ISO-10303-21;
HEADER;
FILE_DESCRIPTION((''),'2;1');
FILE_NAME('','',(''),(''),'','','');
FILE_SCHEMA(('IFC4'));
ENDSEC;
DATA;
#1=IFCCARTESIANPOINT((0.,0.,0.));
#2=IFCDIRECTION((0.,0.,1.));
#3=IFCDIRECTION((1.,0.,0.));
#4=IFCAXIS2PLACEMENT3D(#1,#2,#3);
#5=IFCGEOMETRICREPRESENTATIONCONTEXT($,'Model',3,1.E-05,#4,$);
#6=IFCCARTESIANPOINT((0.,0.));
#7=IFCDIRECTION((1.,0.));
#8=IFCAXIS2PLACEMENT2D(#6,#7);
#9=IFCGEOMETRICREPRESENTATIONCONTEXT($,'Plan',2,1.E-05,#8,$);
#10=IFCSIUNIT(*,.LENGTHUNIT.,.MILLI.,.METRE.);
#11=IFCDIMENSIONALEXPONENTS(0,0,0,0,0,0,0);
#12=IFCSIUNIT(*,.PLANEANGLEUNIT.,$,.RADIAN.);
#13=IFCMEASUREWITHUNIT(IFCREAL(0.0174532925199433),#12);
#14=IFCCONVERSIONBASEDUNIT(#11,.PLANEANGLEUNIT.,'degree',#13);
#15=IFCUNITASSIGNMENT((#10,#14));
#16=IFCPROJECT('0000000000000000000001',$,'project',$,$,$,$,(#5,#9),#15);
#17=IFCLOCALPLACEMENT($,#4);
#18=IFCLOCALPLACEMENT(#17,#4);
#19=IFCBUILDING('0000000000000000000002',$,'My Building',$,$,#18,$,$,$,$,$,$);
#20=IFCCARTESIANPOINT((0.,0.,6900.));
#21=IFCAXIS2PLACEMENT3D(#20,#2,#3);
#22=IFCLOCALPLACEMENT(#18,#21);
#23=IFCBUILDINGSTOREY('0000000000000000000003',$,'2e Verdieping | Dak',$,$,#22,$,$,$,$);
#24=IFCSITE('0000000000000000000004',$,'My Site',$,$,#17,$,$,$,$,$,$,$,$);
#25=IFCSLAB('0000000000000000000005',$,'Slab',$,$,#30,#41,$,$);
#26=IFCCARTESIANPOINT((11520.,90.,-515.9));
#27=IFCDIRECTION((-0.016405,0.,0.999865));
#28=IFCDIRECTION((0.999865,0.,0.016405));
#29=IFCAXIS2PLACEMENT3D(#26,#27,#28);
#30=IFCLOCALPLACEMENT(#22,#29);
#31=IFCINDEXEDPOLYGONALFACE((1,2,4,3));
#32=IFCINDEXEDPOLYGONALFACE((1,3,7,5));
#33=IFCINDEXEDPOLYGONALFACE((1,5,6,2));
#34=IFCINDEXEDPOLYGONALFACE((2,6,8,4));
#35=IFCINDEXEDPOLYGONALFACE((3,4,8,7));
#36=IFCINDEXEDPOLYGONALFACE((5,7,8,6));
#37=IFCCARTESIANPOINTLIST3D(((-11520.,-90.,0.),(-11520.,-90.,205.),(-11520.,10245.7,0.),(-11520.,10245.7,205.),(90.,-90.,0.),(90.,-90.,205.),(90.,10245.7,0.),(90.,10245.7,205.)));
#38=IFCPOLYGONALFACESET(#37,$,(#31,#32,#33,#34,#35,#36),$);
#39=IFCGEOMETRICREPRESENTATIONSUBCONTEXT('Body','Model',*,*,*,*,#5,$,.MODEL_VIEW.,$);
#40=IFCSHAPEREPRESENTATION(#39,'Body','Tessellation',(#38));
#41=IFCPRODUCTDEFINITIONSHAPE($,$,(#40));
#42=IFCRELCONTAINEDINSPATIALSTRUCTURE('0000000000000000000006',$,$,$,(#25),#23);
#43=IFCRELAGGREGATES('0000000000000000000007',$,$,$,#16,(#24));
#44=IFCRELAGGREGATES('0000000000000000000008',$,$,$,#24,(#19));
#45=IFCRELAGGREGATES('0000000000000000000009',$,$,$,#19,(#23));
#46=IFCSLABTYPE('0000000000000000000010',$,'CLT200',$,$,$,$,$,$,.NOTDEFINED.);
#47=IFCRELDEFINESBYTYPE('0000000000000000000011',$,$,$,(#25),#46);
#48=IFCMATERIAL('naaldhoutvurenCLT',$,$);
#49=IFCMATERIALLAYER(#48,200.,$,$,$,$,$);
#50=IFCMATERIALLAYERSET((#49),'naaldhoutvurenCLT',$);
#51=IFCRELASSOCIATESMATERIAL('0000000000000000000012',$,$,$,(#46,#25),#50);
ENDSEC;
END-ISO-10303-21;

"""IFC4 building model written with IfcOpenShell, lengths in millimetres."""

from ifc_helpers import new_model, entity, si_unit, converted_unit, frame, origin_with_axes, origin_2d_with_axis, place, context, subcontext, project, spatial, line, indexed_curve, outline, extrude, material, layer, layer_set, layer_usage, type_object, element, save


model = new_model("IFC4")

# Units and contexts
model_context = context("Model", 3, precision=1e-05, world=origin_with_axes())
plan_context = context("Plan", 2, precision=1e-05, world=origin_2d_with_axis())
body_context = subcontext(model_context, "Body", "Model", "MODEL_VIEW")
ifc_project = project(units=[si_unit("LENGTHUNIT", "METRE", prefix="MILLI"), converted_unit("PLANEANGLEUNIT", "degree", entity("IfcReal", 0.0174532925199433), si_unit("PLANEANGLEUNIT", "RADIAN"), dimensions=[0, 0, 0, 0, 0, 0, 0])], contexts=[model_context, plan_context])

# Site, building, storey
site_placement = place(None, origin_with_axes())
site = spatial("IfcSite", under=ifc_project, at=site_placement, Name="My Site")
building_placement = place(site_placement, origin_with_axes())
building = spatial("IfcBuilding", under=site, at=building_placement, Name="My Building")
storey_placement = place(building_placement, frame((0.0, 0.0, 6900.0), z_axis=(0.0, 0.0, 1.0), x_axis=(1.0, 0.0, 0.0)))
storey = spatial("IfcBuildingStorey", under=building, at=storey_placement, Name="2e Verdieping | Dak")

# Slab
ifc_material_1 = material(Name="naaldhoutvurenCLT")
ifc_layer_1 = layer(ifc_material_1, 200.0)
ifc_layer_set_1 = layer_set([ifc_layer_1], Name="naaldhoutvurenCLT")
ifc_layer_usage_1 = layer_usage(ifc_layer_set_1, "AXIS3", "POSITIVE", 0.0)
slab_type_1 = type_object("IfcSlabType", Name="CLT200", PredefinedType="NOTDEFINED", material=ifc_layer_set_1)
slab_1_placement = place(storey_placement, frame((11520.0, 90.0, -515.9), z_axis=(-0.016405, 0.0, 0.999865), x_axis=(0.999865, 0.0, 0.016405)))
element("IfcSlab", 1, at=slab_1_placement, inside=storey, type_object=slab_type_1, material=ifc_layer_usage_1, Name="Slab", context=body_context, shape_type="SweptSolid", body=[
    extrude(outline(indexed_curve([(90.0, 10245.7), (90.0, -90.0), (-11520.0, -90.0), (-11520.0, 10245.7)], segments=[line(3, 2), line(2, 1), line(1, 4), line(4, 3)], self_intersect=False)), None, (0.0, 0.0, 1.0), 205.0),
])

save(model, "model.ifc")
